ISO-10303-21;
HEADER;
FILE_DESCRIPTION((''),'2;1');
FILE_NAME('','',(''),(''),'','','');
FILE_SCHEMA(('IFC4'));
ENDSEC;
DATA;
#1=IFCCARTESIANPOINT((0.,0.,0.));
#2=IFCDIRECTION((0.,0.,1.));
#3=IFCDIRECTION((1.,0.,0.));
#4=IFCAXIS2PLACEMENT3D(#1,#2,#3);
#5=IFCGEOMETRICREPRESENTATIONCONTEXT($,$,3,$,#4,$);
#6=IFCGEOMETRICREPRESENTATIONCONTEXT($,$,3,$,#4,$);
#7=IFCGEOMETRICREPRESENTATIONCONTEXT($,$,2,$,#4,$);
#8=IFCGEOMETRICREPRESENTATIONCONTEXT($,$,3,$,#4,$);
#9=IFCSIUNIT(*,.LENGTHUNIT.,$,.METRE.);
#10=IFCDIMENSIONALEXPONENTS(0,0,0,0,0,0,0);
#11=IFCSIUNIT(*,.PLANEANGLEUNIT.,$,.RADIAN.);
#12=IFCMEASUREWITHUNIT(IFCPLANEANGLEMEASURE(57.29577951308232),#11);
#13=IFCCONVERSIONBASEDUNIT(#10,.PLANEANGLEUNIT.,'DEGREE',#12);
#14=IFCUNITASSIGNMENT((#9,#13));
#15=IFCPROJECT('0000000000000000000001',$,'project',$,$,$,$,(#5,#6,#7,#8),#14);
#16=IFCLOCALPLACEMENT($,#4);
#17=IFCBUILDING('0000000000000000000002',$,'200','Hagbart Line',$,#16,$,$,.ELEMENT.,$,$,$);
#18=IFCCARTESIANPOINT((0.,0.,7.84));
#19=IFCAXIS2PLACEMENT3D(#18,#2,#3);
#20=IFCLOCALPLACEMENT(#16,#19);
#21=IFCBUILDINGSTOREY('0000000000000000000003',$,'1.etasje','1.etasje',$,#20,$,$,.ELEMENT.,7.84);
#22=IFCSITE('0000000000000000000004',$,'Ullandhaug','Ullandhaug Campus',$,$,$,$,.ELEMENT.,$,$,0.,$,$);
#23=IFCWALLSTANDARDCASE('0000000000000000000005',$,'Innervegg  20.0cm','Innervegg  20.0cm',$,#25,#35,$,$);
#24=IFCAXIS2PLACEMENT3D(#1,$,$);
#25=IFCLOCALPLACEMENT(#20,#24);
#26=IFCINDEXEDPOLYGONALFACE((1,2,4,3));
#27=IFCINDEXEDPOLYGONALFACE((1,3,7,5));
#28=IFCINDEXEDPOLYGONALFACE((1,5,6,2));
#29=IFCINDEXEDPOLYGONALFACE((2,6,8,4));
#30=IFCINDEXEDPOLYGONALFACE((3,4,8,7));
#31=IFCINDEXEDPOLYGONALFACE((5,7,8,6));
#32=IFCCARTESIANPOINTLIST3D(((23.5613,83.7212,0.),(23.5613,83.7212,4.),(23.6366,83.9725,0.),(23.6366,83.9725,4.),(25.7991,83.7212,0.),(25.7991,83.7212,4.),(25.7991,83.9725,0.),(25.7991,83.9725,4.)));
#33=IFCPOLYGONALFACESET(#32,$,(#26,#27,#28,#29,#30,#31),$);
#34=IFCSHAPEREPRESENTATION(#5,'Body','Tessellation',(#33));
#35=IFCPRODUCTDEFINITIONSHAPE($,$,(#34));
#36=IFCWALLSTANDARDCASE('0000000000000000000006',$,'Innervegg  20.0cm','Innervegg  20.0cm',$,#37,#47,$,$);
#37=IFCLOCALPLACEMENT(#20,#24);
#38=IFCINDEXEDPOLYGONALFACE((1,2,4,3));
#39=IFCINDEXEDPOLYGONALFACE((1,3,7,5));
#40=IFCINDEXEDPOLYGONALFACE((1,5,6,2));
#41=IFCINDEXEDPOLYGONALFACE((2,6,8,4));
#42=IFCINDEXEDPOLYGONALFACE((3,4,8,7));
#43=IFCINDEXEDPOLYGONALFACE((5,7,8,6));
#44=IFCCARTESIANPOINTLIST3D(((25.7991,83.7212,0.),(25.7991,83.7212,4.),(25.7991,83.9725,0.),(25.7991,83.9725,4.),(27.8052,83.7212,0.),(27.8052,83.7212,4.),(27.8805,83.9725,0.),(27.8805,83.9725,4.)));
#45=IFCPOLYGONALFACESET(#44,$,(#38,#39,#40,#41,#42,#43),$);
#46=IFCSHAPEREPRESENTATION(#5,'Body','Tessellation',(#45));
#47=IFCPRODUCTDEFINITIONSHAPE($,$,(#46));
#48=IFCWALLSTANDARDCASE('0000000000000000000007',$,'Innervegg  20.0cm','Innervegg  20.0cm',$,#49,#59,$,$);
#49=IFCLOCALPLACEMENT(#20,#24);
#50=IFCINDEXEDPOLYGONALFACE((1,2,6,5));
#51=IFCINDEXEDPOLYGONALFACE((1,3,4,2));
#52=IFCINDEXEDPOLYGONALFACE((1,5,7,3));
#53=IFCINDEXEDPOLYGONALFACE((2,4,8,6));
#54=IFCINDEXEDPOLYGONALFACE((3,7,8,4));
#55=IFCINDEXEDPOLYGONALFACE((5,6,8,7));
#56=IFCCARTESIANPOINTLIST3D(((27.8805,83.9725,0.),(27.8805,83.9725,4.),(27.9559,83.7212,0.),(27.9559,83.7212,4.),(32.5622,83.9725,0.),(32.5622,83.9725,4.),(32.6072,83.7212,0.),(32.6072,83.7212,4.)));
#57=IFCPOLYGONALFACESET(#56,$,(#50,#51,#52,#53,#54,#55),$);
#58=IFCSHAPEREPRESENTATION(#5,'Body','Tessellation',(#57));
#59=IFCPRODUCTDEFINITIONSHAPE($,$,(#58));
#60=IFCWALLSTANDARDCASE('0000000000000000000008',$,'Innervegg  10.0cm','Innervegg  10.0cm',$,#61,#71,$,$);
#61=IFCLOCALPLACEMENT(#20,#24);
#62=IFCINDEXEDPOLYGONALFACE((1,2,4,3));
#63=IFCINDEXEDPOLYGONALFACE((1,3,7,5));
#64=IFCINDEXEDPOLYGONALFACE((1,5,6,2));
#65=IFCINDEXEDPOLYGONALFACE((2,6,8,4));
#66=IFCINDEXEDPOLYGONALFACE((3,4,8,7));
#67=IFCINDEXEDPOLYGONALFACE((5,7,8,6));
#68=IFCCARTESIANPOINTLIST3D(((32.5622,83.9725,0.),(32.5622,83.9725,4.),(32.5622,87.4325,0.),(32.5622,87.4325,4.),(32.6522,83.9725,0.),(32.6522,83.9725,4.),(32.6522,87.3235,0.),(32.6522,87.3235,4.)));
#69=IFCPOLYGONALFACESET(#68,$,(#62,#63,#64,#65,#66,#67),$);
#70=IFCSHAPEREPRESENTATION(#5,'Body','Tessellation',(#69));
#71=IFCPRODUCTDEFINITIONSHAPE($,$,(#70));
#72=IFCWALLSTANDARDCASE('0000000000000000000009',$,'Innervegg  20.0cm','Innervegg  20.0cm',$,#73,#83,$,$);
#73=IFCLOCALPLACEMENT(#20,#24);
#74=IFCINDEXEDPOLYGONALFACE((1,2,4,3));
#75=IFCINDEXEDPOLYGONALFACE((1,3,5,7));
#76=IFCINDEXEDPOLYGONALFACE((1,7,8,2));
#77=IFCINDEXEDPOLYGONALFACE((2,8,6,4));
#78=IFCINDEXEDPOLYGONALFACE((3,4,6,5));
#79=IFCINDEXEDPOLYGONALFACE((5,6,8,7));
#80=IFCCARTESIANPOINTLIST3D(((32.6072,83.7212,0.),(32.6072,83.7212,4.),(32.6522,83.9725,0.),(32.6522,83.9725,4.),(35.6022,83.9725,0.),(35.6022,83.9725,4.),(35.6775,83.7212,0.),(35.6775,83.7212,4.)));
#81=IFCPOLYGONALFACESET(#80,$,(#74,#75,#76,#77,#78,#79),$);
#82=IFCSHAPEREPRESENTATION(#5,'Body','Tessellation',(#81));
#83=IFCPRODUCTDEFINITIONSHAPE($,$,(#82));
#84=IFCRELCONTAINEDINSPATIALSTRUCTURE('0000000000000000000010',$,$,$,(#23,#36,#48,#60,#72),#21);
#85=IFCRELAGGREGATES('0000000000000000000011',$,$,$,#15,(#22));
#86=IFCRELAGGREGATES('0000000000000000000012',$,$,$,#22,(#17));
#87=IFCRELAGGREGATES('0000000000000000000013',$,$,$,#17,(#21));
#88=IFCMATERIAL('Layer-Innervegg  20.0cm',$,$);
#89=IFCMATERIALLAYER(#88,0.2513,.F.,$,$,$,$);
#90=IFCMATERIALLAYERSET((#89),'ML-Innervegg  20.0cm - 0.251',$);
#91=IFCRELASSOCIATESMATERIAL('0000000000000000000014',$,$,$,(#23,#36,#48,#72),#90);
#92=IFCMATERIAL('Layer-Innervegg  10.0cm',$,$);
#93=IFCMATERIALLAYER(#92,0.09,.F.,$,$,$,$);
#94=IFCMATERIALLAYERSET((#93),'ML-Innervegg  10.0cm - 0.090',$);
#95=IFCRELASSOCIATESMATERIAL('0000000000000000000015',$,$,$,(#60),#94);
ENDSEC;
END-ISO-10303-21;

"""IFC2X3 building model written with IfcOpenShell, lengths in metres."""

from ifc_helpers import new_model, entity, si_unit, converted_unit, frame, origin_with_axes, place, context, project, spatial, polyline, outline, extrude, material, layer, layer_set, layer_usage, element, save


model = new_model("IFC2X3")

# Units and contexts
context_of_model_1 = context(None, 3, world=origin_with_axes())
context_of_model_2 = context(None, 3, world=origin_with_axes())
context_of_model_3 = context(None, 2, world=origin_with_axes())
context_of_model_4 = context(None, 3, world=origin_with_axes())
ifc_project = project(units=[si_unit("LENGTHUNIT", "METRE"), converted_unit("PLANEANGLEUNIT", "DEGREE", entity("IfcPlaneAngleMeasure", 57.29577951308232), si_unit("PLANEANGLEUNIT", "RADIAN"), dimensions=[0, 0, 0, 0, 0, 0, 0])], contexts=[context_of_model_1, context_of_model_2, context_of_model_3, context_of_model_4])

# Site, building, storey
site = spatial("IfcSite", under=ifc_project, Name="Ullandhaug", Description="Ullandhaug Campus", CompositionType="ELEMENT", RefElevation=0.0)
building_placement = place(None, origin_with_axes())
building = spatial("IfcBuilding", under=site, at=building_placement, Name="200", Description="Hagbart Line", CompositionType="ELEMENT")
storey_placement = place(building_placement, frame((0.0, 0.0, 7.84), z_axis=(0.0, 0.0, 1.0), x_axis=(1.0, 0.0, 0.0)))
storey = spatial("IfcBuildingStorey", under=building, at=storey_placement, Name="1.etasje", Description="1.etasje", CompositionType="ELEMENT", Elevation=7.84)

# Walls
ifc_material_1 = material(Name="Layer-Innervegg  20.0cm")
ifc_layer_1 = layer(ifc_material_1, 0.2513, ventilated=False)
ifc_layer_set_1 = layer_set([ifc_layer_1], Name="ML-Innervegg  20.0cm - 0.251")
ifc_layer_usage_1 = layer_usage(ifc_layer_set_1, "AXIS2", "POSITIVE", 0.0)
wall_1_placement = place(storey_placement, frame((23.5613, 83.7212, 0.0), z_axis=(0.0, 0.0, 1.0), x_axis=(1.0, 0.0, 0.0)))
element("IfcWallStandardCase", 1, at=wall_1_placement, inside=storey, material=ifc_layer_usage_1, Name="Innervegg  20.0cm", Description="Innervegg  20.0cm", context=context_of_model_1, shape_type="SweptSolid", body=[
    extrude(outline(polyline([(0.0, 0.0), (2.2379, 0.0), (2.2379, 0.2513), (0.0754, 0.2513), (0.0, 0.0)])), origin_with_axes(), (0.0, 0.0, 1.0), 4.0),
])
wall_2_placement = place(storey_placement, frame((25.7991, 83.7212, 0.0), z_axis=(0.0, 0.0, 1.0), x_axis=(1.0, 0.0, 0.0)))
element("IfcWallStandardCase", 2, at=wall_2_placement, inside=storey, material=ifc_layer_usage_1, Name="Innervegg  20.0cm", Description="Innervegg  20.0cm", context=context_of_model_1, shape_type="SweptSolid", body=[
    extrude(outline(polyline([(0.0, 0.0), (2.006, 0.0), (2.0814, 0.2513), (0.0, 0.2513), (0.0, 0.0)])), origin_with_axes(), (0.0, 0.0, 1.0), 4.0),
])
wall_3_placement = place(storey_placement, frame((27.9559, 83.7212, 0.0), z_axis=(0.0, 0.0, 1.0), x_axis=(1.0, 0.0, 0.0)))
element("IfcWallStandardCase", 3, at=wall_3_placement, inside=storey, material=ifc_layer_usage_1, Name="Innervegg  20.0cm", Description="Innervegg  20.0cm", context=context_of_model_1, shape_type="SweptSolid", body=[
    extrude(outline(polyline([(0.0, 0.0), (4.6512, 0.0), (4.6062, 0.2513), (-0.0754, 0.2513), (0.0, 0.0)])), origin_with_axes(), (0.0, 0.0, 1.0), 4.0),
])
ifc_material_2 = material(Name="Layer-Innervegg  10.0cm")
ifc_layer_2 = layer(ifc_material_2, 0.09, ventilated=False)
ifc_layer_set_2 = layer_set([ifc_layer_2], Name="ML-Innervegg  10.0cm - 0.090")
ifc_layer_usage_2 = layer_usage(ifc_layer_set_2, "AXIS2", "POSITIVE", 0.0)
wall_4_placement = place(storey_placement, frame((32.6522, 83.9725, 0.0), z_axis=(0.0, 0.0, 1.0), x_axis=(0.0, 1.0, 0.0)))
element("IfcWallStandardCase", 4, at=wall_4_placement, inside=storey, material=ifc_layer_usage_2, Name="Innervegg  10.0cm", Description="Innervegg  10.0cm", context=context_of_model_1, shape_type="SweptSolid", body=[
    extrude(outline(polyline([(0.0, 0.0), (3.351, 0.0), (3.46, 0.09), (0.0, 0.09), (0.0, 0.0)])), frame((0.0, 0.0, 0.0), z_axis=(0.0, 0.0, 1.0), x_axis=(1.0, 0.0, 0.0)), (0.0, 0.0, 1.0), 4.0),
])
wall_5_placement = place(storey_placement, frame((32.6072, 83.7212, 0.0), z_axis=(0.0, 0.0, 1.0), x_axis=(1.0, 0.0, 0.0)))
element("IfcWallStandardCase", 5, at=wall_5_placement, inside=storey, material=ifc_layer_usage_1, Name="Innervegg  20.0cm", Description="Innervegg  20.0cm", context=context_of_model_1, shape_type="SweptSolid", body=[
    extrude(outline(polyline([(0.0, 0.0), (3.0704, 0.0), (2.995, 0.2513), (0.045, 0.2513), (0.0, 0.0)])), origin_with_axes(), (0.0, 0.0, 1.0), 4.0),
])

save(model, "model.ifc")
